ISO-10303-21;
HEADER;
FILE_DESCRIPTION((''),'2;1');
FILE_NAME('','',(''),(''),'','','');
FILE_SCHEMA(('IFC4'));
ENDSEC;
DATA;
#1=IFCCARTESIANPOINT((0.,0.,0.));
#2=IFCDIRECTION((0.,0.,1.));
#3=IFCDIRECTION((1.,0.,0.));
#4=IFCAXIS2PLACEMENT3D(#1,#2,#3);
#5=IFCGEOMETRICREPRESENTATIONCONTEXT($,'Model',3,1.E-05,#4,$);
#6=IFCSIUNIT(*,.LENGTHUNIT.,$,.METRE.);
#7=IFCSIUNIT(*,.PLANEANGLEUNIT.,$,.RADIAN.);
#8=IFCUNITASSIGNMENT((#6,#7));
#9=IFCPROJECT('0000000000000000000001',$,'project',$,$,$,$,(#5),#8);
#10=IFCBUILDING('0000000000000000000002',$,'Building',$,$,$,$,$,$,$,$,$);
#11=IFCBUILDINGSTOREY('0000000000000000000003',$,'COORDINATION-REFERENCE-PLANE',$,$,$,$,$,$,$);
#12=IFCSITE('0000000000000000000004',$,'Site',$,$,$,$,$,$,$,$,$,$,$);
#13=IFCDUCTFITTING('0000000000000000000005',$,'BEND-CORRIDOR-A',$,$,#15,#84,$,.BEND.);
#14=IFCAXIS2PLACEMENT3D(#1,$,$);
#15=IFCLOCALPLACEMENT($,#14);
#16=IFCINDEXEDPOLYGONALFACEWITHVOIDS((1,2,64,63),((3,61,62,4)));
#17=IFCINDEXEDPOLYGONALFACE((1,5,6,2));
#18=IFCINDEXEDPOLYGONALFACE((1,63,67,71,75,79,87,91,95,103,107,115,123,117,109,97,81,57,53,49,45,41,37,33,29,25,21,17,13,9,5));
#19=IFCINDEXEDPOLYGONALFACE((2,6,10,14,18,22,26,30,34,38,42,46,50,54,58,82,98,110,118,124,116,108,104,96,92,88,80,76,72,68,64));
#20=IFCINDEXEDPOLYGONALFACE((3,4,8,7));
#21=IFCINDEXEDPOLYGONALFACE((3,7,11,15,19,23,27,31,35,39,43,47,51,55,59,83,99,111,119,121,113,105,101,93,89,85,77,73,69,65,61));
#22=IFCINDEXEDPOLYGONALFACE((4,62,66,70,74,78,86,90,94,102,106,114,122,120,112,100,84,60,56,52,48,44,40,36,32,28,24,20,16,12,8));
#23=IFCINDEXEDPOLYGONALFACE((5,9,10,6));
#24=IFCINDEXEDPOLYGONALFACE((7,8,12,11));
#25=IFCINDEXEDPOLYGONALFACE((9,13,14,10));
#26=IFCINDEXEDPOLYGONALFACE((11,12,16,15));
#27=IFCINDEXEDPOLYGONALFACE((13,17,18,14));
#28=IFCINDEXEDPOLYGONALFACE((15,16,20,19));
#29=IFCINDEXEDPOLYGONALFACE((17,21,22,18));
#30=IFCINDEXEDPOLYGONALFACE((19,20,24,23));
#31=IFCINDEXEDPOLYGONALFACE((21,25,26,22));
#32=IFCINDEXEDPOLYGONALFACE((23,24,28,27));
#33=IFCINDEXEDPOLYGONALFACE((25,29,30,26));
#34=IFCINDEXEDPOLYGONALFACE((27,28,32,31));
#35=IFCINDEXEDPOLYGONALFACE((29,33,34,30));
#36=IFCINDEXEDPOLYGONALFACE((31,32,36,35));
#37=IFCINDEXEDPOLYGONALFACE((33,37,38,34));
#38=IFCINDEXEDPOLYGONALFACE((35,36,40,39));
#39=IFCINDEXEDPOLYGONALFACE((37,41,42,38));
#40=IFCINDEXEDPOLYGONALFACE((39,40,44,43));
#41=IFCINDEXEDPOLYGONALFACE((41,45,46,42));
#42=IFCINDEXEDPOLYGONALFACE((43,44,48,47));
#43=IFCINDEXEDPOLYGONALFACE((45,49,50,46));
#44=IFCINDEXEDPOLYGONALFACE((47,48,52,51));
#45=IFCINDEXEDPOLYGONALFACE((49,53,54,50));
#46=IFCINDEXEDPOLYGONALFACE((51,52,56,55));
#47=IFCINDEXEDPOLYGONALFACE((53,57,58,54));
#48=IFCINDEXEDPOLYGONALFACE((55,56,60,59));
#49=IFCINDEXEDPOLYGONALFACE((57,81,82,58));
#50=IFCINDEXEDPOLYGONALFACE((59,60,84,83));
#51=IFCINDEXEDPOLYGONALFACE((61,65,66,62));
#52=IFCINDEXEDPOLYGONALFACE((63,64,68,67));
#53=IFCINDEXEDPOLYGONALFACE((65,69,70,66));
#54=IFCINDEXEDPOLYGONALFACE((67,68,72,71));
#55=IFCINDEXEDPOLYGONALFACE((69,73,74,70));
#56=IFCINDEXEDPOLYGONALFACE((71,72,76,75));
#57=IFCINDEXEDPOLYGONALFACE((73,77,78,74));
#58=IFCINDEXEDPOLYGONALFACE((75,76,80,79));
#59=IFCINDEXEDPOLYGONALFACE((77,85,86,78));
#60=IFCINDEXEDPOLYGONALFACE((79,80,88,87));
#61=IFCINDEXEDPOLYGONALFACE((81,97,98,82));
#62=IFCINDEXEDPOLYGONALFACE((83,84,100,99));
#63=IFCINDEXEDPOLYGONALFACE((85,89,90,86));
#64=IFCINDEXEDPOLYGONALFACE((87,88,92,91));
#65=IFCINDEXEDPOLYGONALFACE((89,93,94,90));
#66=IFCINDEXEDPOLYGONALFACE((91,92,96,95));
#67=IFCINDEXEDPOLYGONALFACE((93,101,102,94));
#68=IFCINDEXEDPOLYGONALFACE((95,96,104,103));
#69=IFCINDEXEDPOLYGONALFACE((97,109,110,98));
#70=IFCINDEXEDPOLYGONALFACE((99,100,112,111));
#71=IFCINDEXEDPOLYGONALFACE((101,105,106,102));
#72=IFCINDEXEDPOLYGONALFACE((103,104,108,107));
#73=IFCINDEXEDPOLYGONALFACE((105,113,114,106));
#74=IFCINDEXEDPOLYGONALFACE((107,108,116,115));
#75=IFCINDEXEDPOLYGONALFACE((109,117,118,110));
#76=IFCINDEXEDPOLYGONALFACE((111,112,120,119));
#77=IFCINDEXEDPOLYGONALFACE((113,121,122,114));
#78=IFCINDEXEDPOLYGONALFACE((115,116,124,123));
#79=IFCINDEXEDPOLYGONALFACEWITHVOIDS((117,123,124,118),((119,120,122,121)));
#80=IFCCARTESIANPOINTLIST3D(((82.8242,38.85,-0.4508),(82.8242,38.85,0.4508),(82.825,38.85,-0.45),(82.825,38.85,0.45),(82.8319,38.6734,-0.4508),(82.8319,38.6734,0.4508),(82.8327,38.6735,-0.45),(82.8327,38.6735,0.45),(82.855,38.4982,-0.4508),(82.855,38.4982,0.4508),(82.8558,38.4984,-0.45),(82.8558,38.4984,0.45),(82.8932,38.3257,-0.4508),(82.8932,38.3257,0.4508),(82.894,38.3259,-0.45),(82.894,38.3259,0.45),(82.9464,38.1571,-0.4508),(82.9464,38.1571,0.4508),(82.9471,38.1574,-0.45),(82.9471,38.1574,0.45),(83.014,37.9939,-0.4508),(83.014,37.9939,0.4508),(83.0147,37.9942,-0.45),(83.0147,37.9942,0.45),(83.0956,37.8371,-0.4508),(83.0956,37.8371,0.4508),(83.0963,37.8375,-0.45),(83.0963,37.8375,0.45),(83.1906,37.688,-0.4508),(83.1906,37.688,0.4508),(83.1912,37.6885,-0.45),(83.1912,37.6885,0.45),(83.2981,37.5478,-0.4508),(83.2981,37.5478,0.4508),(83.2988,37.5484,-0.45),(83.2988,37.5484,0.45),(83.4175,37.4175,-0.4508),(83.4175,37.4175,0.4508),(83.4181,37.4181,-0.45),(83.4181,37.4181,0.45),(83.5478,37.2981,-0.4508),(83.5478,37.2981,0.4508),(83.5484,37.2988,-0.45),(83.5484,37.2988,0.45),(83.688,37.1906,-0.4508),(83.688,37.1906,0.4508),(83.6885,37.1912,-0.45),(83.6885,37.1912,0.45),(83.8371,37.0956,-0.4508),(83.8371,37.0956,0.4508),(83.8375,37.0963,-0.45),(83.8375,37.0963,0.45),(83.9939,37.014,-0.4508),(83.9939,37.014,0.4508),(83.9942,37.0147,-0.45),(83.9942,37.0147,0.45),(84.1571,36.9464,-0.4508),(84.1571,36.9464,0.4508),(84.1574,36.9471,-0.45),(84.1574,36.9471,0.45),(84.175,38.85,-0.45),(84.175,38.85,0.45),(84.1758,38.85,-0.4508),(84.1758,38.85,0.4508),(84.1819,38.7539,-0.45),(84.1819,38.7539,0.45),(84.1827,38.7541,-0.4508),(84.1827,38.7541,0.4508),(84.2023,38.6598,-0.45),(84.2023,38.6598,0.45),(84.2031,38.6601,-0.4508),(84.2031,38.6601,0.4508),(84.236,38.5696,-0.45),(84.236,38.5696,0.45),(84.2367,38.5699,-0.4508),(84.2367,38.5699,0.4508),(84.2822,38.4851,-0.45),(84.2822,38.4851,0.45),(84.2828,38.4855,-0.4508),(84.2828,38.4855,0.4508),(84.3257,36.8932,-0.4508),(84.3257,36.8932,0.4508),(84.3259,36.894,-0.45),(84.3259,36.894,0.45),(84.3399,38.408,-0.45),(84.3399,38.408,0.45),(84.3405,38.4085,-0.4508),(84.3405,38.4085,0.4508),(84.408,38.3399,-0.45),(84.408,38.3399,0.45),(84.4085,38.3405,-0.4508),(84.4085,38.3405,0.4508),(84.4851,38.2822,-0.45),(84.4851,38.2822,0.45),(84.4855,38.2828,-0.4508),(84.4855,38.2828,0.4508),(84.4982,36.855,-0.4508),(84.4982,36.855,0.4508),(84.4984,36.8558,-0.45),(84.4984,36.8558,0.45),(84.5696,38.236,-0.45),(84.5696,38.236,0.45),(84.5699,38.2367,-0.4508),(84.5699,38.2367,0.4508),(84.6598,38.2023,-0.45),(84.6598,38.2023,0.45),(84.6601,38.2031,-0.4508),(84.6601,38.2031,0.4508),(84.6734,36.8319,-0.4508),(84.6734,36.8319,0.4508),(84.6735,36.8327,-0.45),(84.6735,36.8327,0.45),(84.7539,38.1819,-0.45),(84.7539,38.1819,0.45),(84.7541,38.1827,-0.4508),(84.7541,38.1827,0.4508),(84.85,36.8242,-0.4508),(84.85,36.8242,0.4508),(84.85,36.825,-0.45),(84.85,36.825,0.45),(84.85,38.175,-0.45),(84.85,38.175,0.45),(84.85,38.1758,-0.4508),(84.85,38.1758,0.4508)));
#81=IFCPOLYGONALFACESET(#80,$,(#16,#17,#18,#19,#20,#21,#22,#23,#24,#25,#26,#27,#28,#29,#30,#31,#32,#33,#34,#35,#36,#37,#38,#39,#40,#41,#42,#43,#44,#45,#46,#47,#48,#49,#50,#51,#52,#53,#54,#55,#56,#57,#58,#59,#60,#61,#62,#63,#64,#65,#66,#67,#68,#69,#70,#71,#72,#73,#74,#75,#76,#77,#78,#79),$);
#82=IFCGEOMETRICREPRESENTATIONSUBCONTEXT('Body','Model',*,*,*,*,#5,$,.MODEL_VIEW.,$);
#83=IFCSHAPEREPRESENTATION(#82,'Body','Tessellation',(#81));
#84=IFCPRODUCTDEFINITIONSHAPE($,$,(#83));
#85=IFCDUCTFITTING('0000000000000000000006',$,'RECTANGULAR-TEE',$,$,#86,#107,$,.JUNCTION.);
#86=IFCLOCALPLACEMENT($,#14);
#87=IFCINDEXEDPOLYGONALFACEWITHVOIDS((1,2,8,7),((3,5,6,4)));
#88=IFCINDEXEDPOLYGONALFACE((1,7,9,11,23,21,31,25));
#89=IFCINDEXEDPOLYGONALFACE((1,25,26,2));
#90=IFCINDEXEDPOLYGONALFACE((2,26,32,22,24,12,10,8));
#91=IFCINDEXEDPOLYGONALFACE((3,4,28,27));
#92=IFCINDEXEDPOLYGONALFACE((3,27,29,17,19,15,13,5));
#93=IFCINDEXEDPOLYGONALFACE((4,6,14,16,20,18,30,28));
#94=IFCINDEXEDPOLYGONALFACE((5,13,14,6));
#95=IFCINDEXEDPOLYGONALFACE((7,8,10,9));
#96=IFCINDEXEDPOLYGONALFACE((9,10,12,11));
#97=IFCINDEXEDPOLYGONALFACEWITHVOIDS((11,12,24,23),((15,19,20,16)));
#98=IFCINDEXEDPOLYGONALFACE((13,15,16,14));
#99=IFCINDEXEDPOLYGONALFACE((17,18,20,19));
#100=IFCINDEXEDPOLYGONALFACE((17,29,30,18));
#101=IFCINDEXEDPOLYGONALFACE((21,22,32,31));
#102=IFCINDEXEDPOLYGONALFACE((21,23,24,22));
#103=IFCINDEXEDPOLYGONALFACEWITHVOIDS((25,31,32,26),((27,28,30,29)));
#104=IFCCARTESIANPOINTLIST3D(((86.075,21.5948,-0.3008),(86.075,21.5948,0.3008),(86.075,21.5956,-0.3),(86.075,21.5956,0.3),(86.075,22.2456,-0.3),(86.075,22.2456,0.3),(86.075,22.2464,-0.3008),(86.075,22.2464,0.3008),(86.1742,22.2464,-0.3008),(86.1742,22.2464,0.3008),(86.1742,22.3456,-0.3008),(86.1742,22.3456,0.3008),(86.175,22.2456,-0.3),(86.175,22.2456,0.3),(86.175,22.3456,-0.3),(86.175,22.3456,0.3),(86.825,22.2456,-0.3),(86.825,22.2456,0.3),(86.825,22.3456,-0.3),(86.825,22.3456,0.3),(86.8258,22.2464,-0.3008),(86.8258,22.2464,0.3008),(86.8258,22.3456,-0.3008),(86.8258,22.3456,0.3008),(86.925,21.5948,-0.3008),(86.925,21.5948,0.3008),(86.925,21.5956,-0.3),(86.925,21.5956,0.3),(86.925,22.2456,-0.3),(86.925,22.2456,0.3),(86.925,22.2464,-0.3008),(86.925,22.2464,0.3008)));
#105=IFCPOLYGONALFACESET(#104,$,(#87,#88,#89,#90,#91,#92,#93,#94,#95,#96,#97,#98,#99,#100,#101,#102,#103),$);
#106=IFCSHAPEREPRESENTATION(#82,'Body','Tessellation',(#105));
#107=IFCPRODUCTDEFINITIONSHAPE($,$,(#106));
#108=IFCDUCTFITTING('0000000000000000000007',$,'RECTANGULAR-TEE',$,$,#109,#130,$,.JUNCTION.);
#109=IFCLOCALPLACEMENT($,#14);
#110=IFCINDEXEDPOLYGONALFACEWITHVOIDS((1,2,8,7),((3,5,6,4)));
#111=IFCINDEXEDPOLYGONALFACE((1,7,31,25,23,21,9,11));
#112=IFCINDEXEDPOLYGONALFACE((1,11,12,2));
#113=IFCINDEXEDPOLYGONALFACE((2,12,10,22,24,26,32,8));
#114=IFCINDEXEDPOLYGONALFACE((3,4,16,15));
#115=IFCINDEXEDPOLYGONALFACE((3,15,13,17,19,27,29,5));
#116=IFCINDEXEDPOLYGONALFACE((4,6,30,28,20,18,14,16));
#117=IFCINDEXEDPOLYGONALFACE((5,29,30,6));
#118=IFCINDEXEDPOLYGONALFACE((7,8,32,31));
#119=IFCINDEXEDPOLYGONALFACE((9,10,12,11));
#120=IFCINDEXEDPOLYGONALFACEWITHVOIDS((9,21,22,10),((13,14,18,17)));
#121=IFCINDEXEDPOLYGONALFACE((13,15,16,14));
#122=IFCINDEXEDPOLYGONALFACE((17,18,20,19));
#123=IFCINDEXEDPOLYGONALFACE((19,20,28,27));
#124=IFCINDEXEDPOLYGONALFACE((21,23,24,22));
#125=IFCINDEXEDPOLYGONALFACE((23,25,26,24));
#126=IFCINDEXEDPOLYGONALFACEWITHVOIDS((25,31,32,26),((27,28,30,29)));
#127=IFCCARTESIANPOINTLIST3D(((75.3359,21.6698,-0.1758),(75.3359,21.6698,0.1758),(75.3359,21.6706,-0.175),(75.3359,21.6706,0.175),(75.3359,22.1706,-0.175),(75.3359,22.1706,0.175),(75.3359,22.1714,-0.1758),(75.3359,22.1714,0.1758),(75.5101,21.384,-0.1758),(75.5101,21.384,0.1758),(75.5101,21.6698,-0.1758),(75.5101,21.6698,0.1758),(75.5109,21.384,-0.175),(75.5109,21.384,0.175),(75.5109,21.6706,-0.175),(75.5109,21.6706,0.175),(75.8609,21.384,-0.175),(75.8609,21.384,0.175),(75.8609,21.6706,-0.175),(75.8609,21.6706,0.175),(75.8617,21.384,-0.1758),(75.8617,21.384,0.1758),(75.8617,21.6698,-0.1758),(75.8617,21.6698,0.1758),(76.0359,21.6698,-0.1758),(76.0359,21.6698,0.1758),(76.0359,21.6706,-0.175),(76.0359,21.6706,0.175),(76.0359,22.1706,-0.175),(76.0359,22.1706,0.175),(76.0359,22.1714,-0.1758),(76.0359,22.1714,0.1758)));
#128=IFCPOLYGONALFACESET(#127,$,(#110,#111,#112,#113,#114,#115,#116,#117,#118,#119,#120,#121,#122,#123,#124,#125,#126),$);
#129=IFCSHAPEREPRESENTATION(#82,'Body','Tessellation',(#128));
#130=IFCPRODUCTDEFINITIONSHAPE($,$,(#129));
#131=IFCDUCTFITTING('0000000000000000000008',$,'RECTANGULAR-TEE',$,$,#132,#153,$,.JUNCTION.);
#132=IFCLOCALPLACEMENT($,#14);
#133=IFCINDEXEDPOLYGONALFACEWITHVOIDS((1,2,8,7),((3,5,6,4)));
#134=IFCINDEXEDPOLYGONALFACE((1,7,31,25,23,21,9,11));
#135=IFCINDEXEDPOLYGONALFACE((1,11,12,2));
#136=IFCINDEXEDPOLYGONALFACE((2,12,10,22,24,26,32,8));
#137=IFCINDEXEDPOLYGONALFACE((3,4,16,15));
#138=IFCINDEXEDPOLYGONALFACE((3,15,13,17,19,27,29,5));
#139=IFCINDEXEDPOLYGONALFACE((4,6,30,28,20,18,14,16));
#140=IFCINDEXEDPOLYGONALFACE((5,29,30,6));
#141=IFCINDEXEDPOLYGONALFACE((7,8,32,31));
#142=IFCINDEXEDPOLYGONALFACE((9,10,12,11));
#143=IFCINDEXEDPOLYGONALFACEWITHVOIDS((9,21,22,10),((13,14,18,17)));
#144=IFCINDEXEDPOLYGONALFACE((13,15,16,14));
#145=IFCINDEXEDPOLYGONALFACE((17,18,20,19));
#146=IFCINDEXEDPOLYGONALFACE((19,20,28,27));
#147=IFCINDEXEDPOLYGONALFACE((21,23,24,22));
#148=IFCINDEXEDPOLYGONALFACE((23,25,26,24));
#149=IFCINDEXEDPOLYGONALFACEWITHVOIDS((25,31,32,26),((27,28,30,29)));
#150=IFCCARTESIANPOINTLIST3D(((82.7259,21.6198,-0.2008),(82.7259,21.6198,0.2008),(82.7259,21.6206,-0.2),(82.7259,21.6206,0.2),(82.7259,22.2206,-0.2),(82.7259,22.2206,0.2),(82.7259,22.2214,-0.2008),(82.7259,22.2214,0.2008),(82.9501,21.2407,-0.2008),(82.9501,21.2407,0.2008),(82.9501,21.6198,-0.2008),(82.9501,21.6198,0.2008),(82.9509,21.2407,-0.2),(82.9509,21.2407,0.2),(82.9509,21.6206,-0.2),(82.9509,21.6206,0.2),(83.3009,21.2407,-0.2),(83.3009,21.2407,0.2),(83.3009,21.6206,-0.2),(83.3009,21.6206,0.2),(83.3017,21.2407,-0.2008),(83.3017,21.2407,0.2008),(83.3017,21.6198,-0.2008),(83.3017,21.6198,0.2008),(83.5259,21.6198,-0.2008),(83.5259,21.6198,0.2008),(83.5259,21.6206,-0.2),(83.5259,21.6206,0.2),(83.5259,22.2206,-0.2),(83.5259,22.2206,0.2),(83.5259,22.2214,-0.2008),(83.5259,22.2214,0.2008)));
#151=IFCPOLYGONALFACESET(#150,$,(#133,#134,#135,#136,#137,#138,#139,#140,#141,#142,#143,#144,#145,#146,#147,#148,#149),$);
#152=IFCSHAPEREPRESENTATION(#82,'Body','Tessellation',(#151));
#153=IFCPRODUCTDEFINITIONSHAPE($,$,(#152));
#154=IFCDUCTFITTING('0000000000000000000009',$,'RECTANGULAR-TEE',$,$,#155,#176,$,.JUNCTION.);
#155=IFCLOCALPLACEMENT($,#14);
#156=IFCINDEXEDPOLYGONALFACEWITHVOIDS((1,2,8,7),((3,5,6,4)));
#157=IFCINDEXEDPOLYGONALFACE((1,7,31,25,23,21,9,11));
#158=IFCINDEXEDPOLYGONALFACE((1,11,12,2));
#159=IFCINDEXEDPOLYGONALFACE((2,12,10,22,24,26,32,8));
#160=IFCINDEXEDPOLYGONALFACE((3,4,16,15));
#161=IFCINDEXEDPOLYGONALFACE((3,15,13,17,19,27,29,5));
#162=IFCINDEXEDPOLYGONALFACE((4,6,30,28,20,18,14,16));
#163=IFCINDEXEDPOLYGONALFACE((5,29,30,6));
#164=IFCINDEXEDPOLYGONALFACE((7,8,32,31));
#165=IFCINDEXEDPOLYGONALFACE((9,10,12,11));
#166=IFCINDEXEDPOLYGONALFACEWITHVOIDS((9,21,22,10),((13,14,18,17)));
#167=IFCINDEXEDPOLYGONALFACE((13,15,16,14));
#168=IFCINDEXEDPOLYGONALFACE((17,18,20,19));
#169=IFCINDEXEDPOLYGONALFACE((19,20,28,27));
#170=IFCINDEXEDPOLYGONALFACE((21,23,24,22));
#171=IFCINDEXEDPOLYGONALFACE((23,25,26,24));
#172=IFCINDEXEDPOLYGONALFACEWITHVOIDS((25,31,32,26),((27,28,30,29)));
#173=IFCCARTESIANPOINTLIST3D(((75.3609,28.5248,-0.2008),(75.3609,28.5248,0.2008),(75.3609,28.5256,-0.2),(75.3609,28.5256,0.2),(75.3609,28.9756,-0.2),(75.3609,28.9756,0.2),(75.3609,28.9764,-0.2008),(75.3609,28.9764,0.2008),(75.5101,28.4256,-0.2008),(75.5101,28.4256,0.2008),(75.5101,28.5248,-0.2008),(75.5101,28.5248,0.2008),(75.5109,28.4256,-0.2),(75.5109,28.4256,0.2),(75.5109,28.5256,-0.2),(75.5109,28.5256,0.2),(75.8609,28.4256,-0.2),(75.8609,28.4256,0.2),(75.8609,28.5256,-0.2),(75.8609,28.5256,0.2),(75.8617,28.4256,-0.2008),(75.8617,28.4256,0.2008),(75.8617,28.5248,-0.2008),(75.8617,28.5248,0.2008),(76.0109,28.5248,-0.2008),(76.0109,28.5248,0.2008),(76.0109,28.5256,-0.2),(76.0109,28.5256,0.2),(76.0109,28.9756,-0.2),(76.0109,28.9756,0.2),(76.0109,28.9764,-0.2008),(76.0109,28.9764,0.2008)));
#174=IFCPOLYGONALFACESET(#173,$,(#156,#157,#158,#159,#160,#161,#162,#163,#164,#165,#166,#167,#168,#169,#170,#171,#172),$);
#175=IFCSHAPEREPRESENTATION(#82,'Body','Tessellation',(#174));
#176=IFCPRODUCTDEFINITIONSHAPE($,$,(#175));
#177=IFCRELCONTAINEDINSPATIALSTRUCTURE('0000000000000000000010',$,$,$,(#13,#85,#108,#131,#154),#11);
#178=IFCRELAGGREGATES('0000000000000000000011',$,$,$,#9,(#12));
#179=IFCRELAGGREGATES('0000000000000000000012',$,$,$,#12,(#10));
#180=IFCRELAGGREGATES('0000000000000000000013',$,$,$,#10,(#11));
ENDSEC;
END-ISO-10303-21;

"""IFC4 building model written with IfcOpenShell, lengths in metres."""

from ifc_helpers import new_model, entity, si_unit, frame, origin_with_axes, place, context, subcontext, project, spatial, rectangle, extrude, boolean, element, save


model = new_model("IFC4")

# Units and contexts
model_context = context("Model", 3, precision=1e-05, world=origin_with_axes())
body_context = subcontext(model_context, "Body", "Model", "MODEL_VIEW")
ifc_project = project(units=[si_unit("LENGTHUNIT", "METRE"), si_unit("PLANEANGLEUNIT", "RADIAN")], contexts=[model_context])

# Site, building, storey
site = spatial("IfcSite", under=ifc_project, Name="Site")
building = spatial("IfcBuilding", under=site, Name="Building")
storey = spatial("IfcBuildingStorey", under=building, Name="COORDINATION-REFERENCE-PLANE")

# Duct fittings
duct_fitting_1_placement = place(None, frame((84.85, 38.85, 0.0), z_axis=(0.0, 0.0, 1.0), x_axis=(-1.0, 0.0, 0.0)))
cartesian_point_1 = entity("IfcCartesianPoint", [0.0, 0.0, 0.0])
element("IfcDuctFitting", 1, at=duct_fitting_1_placement, inside=storey, Name="BEND-CORRIDOR-A", PredefinedType="BEND", context=body_context, shape_type="SweptSolid", body=[
    entity("IfcRevolvedAreaSolid", entity("IfcRectangleHollowProfileDef", "AREA", None, entity("IfcAxis2Placement2D", entity("IfcCartesianPoint", [1.35, 0.0])), 1.3516, 0.9016, 0.0008), entity("IfcAxis2Placement3D", cartesian_point_1, entity("IfcDirection", [0.0, -1.0, 0.0]), entity("IfcDirection", [1.0, 0.0, 0.0])), entity("IfcAxis1Placement", cartesian_point_1, entity("IfcDirection", [0.0, 1.0, 0.0])), 1.570796),
])
duct_fitting_2_placement = place(None, frame((86.5, 21.9206, 0.0), z_axis=(1.0, 0.0, 0.0), x_axis=(0.0, 1.0, 0.0)))
solid_1 = boolean("UNION", extrude(rectangle(XDim=0.65, YDim=0.6), frame((0.0, 0.0, -0.425), z_axis=(0.0, 0.0, 1.0), x_axis=(1.0, 0.0, 0.0)), (0.0, 0.0, 1.0), 0.85), extrude(rectangle(XDim=0.65, YDim=0.6), frame((0.0, 0.0, 0.0), z_axis=(1.0, 0.0, 0.0), x_axis=(0.0, 0.0, -1.0)), (0.0, 0.0, 1.0), 0.425))
element("IfcDuctFitting", 2, at=duct_fitting_2_placement, inside=storey, Name="RECTANGULAR-TEE", PredefinedType="JUNCTION", context=body_context, shape_type="CSG", body=[
    boolean("DIFFERENCE", boolean("UNION", extrude(rectangle(XDim=0.6516, YDim=0.6016), frame((0.0, 0.0, -0.425), z_axis=(0.0, 0.0, 1.0), x_axis=(1.0, 0.0, 0.0)), (0.0, 0.0, 1.0), 0.85), extrude(rectangle(XDim=0.6516, YDim=0.6016), frame((0.0, 0.0, 0.0), z_axis=(1.0, 0.0, 0.0), x_axis=(0.0, 0.0, -1.0)), (0.0, 0.0, 1.0), 0.425)), solid_1),
])
duct_fitting_3_placement = place(None, frame((75.6859, 21.9206, 0.0), z_axis=(-1.0, 0.0, 0.0), x_axis=(0.0, -1.0, 0.0)))
solid_2 = boolean("UNION", extrude(rectangle(XDim=0.5, YDim=0.35), frame((0.0, 0.0, -0.35), z_axis=(0.0, 0.0, 1.0), x_axis=(1.0, 0.0, 0.0)), (0.0, 0.0, 1.0), 0.7), extrude(rectangle(XDim=0.35, YDim=0.35), frame((0.0, 0.0, 0.0), z_axis=(1.0, 0.0, 0.0), x_axis=(0.0, 0.0, -1.0)), (0.0, 0.0, 1.0), 0.5366))
element("IfcDuctFitting", 3, at=duct_fitting_3_placement, inside=storey, Name="RECTANGULAR-TEE", PredefinedType="JUNCTION", context=body_context, shape_type="CSG", body=[
    boolean("DIFFERENCE", boolean("UNION", extrude(rectangle(XDim=0.5016, YDim=0.3516), frame((0.0, 0.0, -0.35), z_axis=(0.0, 0.0, 1.0), x_axis=(1.0, 0.0, 0.0)), (0.0, 0.0, 1.0), 0.7), extrude(rectangle(XDim=0.3516, YDim=0.3516), frame((0.0, 0.0, 0.0), z_axis=(1.0, 0.0, 0.0), x_axis=(0.0, 0.0, -1.0)), (0.0, 0.0, 1.0), 0.5366)), solid_2),
])
duct_fitting_4_placement = place(None, frame((83.1259, 21.9206, 0.0), z_axis=(-1.0, 0.0, 0.0), x_axis=(0.0, -1.0, 0.0)))
solid_3 = boolean("UNION", extrude(rectangle(XDim=0.6, YDim=0.4), frame((0.0, 0.0, -0.4), z_axis=(0.0, 0.0, 1.0), x_axis=(1.0, 0.0, 0.0)), (0.0, 0.0, 1.0), 0.8), extrude(rectangle(XDim=0.35, YDim=0.4), frame((0.0, 0.0, 0.0), z_axis=(1.0, 0.0, 0.0), x_axis=(0.0, 0.0, -1.0)), (0.0, 0.0, 1.0), 0.6799))
element("IfcDuctFitting", 4, at=duct_fitting_4_placement, inside=storey, Name="RECTANGULAR-TEE", PredefinedType="JUNCTION", context=body_context, shape_type="CSG", body=[
    boolean("DIFFERENCE", boolean("UNION", extrude(rectangle(XDim=0.6016, YDim=0.4016), frame((0.0, 0.0, -0.4), z_axis=(0.0, 0.0, 1.0), x_axis=(1.0, 0.0, 0.0)), (0.0, 0.0, 1.0), 0.8), extrude(rectangle(XDim=0.3516, YDim=0.4016), frame((0.0, 0.0, 0.0), z_axis=(1.0, 0.0, 0.0), x_axis=(0.0, 0.0, -1.0)), (0.0, 0.0, 1.0), 0.6799)), solid_3),
])
duct_fitting_5_placement = place(None, frame((75.6859, 28.7506, 0.0), z_axis=(-1.0, 0.0, 0.0), x_axis=(0.0, -1.0, 0.0)))
solid_4 = boolean("UNION", extrude(rectangle(XDim=0.45, YDim=0.4), frame((0.0, 0.0, -0.325), z_axis=(0.0, 0.0, 1.0), x_axis=(1.0, 0.0, 0.0)), (0.0, 0.0, 1.0), 0.65), extrude(rectangle(XDim=0.35, YDim=0.4), frame((0.0, 0.0, 0.0), z_axis=(1.0, 0.0, 0.0), x_axis=(0.0, 0.0, -1.0)), (0.0, 0.0, 1.0), 0.325))
element("IfcDuctFitting", 5, at=duct_fitting_5_placement, inside=storey, Name="RECTANGULAR-TEE", PredefinedType="JUNCTION", context=body_context, shape_type="CSG", body=[
    boolean("DIFFERENCE", boolean("UNION", extrude(rectangle(XDim=0.4516, YDim=0.4016), frame((0.0, 0.0, -0.325), z_axis=(0.0, 0.0, 1.0), x_axis=(1.0, 0.0, 0.0)), (0.0, 0.0, 1.0), 0.65), extrude(rectangle(XDim=0.3516, YDim=0.4016), frame((0.0, 0.0, 0.0), z_axis=(1.0, 0.0, 0.0), x_axis=(0.0, 0.0, -1.0)), (0.0, 0.0, 1.0), 0.325)), solid_4),
])

save(model, "model.ifc")
